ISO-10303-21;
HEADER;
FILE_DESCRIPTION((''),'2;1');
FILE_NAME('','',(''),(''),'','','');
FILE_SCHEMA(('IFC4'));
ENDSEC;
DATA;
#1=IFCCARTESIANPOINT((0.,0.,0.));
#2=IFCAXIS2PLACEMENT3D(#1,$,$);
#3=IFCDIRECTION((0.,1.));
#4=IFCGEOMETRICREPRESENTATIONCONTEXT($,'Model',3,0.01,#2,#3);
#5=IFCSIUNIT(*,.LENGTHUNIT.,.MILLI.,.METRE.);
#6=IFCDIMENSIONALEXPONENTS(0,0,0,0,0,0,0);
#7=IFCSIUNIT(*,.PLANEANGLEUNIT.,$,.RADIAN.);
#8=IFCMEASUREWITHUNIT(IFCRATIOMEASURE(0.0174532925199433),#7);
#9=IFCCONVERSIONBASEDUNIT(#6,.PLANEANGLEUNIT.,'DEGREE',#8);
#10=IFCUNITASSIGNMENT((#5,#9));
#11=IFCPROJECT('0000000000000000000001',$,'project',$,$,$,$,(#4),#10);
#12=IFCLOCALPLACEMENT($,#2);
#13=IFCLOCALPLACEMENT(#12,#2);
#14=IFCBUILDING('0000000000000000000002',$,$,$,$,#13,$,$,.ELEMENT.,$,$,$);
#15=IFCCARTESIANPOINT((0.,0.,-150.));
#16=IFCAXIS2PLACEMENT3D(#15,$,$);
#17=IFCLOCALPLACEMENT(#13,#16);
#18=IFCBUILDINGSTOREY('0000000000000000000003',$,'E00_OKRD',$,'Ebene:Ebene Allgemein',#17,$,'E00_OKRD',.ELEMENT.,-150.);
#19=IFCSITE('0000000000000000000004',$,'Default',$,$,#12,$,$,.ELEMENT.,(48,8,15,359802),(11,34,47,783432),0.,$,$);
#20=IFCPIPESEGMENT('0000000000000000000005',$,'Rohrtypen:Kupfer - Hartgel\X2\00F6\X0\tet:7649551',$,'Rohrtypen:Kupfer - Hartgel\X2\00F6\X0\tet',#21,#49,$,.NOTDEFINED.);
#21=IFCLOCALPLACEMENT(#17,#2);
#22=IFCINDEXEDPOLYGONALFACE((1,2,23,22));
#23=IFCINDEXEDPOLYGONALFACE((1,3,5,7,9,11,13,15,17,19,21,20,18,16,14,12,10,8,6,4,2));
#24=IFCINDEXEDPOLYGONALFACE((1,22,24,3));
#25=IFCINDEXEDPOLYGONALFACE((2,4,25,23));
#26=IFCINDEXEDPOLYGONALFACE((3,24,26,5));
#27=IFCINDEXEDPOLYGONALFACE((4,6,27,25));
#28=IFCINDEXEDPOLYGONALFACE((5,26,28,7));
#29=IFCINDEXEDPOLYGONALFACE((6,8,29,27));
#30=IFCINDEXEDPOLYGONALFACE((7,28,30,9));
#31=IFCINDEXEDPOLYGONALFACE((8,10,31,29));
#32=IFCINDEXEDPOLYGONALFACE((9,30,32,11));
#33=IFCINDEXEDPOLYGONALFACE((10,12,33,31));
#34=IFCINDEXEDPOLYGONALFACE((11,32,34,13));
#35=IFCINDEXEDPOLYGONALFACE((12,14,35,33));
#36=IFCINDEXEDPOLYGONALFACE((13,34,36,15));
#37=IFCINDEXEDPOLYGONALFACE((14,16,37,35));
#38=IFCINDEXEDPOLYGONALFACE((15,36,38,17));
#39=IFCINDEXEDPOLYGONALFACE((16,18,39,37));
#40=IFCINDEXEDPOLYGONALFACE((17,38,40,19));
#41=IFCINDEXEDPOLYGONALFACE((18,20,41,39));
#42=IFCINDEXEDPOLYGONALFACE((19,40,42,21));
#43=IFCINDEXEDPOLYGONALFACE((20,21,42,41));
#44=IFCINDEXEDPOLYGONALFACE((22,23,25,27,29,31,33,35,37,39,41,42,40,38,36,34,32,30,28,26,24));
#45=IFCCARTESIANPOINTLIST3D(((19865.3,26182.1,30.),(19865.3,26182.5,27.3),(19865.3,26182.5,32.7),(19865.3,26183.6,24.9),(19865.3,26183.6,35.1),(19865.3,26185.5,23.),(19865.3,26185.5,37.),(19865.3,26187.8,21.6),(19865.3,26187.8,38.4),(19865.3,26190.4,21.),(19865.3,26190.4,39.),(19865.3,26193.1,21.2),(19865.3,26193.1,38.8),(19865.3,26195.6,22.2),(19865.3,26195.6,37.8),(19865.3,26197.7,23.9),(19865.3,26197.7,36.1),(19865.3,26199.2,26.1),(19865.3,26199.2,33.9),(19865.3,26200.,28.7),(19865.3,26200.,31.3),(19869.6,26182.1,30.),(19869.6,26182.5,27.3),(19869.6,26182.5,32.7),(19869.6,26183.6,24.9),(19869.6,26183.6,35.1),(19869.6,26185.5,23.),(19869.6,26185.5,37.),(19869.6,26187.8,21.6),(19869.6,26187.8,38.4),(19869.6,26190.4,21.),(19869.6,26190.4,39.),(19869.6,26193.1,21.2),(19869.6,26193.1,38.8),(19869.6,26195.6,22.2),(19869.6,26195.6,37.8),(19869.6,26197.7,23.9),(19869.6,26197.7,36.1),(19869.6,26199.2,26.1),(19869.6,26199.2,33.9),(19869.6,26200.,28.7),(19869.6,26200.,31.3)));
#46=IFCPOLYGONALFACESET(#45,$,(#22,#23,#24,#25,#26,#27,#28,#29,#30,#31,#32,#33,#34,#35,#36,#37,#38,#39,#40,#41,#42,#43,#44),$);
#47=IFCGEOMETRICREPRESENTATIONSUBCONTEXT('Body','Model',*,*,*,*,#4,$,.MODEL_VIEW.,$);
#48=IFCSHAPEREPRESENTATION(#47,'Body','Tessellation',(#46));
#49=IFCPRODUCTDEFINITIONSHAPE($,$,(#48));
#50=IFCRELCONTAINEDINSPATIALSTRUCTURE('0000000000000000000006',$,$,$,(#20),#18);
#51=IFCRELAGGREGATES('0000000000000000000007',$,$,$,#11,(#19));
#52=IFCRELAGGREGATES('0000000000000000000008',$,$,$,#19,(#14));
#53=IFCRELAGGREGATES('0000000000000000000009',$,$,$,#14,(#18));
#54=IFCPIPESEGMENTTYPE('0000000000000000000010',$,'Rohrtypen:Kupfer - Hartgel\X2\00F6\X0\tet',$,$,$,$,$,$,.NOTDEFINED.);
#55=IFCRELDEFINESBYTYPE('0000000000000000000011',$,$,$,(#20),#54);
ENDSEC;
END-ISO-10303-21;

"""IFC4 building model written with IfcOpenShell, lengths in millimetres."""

from ifc_helpers import new_model, entity, si_unit, converted_unit, direction, frame, frame_2d, origin, place, context, subcontext, project, spatial, circle, extrude, type_object, element, save


model = new_model("IFC4")

# Units and contexts
model_context = context("Model", 3, precision=0.01, world=origin(), true_north=direction((0.0, 1.0)))
body_context = subcontext(model_context, "Body", "Model", "MODEL_VIEW")
ifc_project = project(units=[si_unit("LENGTHUNIT", "METRE", prefix="MILLI"), converted_unit("PLANEANGLEUNIT", "DEGREE", entity("IfcRatioMeasure", 0.0174532925199433), si_unit("PLANEANGLEUNIT", "RADIAN"), dimensions=[0, 0, 0, 0, 0, 0, 0])], contexts=[model_context])

# Site, building, storey
site_placement = place(None, origin())
site = spatial("IfcSite", under=ifc_project, at=site_placement, Name="Default", CompositionType="ELEMENT", RefLatitude=(48, 8, 15, 359802), RefLongitude=(11, 34, 47, 783432), RefElevation=0.0)
building_placement = place(site_placement, origin())
building = spatial("IfcBuilding", under=site, at=building_placement, CompositionType="ELEMENT")
storey_placement = place(building_placement, frame((0.0, 0.0, -150.0)))
storey = spatial("IfcBuildingStorey", under=building, at=storey_placement, Name="E00_OKRD", ObjectType="Ebene:Ebene Allgemein", LongName="E00_OKRD", CompositionType="ELEMENT", Elevation=-150.0)

# Pipe segment
pipe_segment_type = type_object("IfcPipeSegmentType", Name="Rohrtypen:Kupfer - Hartgelötet", PredefinedType="NOTDEFINED")
pipe_segment_1_placement = place(storey_placement, frame((19865.3, 26180.5, 19.4)))
element("IfcPipeSegment", 1, at=pipe_segment_1_placement, inside=storey, type_object=pipe_segment_type, Name="Rohrtypen:Kupfer - Hartgelötet:7649551", ObjectType="Rohrtypen:Kupfer - Hartgelötet", PredefinedType="NOTDEFINED", context=body_context, shape_type="SweptSolid", body=[
    extrude(circle(Radius=9.0, at=frame_2d((0.0, 0.0), x_axis=(1.0, 0.0))), frame((0.0, 10.6, 10.6), z_axis=(1.0, -0.000088, 0.0), x_axis=(-0.000088, -1.0, 0.0)), (0.0, 0.0, 1.0), 4.2),
])

save(model, "model.ifc")
